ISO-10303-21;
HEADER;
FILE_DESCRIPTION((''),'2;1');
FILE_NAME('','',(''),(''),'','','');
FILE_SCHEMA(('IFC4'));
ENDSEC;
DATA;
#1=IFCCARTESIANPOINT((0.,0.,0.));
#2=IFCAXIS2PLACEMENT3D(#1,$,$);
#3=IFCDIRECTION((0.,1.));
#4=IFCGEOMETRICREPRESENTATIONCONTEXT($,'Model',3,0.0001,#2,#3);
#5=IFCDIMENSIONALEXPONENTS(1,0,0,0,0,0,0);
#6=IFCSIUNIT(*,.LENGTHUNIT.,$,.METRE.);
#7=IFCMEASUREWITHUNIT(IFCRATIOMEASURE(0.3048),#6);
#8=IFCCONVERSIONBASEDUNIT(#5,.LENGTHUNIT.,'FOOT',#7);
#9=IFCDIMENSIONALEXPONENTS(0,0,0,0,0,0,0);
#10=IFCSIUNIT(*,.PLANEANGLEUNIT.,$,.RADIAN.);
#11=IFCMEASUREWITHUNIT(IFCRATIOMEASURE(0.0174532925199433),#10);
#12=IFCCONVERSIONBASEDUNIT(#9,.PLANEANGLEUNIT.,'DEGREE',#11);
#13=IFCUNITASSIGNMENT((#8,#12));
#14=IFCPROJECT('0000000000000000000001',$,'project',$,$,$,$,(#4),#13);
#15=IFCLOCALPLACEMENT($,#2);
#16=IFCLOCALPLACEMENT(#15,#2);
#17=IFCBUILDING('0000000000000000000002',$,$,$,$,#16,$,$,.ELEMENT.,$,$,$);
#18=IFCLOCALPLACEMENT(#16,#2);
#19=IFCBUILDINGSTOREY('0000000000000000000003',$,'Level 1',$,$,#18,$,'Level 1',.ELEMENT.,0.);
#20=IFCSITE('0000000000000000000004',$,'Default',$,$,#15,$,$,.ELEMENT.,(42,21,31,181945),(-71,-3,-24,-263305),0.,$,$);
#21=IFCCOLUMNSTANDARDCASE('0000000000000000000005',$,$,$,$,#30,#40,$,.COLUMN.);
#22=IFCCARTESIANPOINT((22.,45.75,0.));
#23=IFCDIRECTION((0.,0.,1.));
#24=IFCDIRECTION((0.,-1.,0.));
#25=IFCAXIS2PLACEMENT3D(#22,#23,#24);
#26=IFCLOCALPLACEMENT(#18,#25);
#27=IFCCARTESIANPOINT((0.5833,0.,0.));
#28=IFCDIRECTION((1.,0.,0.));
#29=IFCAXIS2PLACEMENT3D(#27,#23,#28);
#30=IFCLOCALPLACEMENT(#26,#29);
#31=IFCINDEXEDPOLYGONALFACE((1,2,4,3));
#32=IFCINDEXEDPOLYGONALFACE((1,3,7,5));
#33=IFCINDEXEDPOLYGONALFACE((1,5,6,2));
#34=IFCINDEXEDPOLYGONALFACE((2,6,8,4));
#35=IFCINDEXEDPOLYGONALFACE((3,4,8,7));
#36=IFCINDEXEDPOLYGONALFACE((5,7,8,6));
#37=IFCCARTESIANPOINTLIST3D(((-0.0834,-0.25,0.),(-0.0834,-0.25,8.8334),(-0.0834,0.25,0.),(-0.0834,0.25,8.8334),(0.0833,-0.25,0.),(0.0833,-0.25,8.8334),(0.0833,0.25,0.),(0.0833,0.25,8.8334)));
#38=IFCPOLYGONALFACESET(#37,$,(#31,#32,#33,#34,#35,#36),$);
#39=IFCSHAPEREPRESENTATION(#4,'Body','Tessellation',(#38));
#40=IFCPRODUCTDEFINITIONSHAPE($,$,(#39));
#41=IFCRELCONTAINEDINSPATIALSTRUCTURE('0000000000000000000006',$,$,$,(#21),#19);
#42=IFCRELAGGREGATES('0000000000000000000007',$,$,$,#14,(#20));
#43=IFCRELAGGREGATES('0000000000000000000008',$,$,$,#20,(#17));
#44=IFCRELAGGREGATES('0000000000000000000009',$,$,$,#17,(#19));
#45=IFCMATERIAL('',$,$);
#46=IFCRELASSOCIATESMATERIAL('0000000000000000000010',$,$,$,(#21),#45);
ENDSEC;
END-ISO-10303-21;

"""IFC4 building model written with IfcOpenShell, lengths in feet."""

from ifc_helpers import new_model, entity, si_unit, converted_unit, direction, frame, origin, place, context, project, spatial, rectangle, extrude, material, element, save


model = new_model("IFC4")

# Units and contexts
model_context = context("Model", 3, precision=0.0001, world=origin(), true_north=direction((0.0, 1.0)))
ifc_project = project(units=[converted_unit("LENGTHUNIT", "FOOT", entity("IfcRatioMeasure", 0.3048), si_unit("LENGTHUNIT", "METRE"), dimensions=[1, 0, 0, 0, 0, 0, 0]), converted_unit("PLANEANGLEUNIT", "DEGREE", entity("IfcRatioMeasure", 0.0174532925199433), si_unit("PLANEANGLEUNIT", "RADIAN"), dimensions=[0, 0, 0, 0, 0, 0, 0])], contexts=[model_context])

# Site, building, storey
site_placement = place(None, origin())
site = spatial("IfcSite", under=ifc_project, at=site_placement, Name="Default", CompositionType="ELEMENT", RefLatitude=(42, 21, 31, 181945), RefLongitude=(-71, -3, -24, -263305), RefElevation=0.0)
building_placement = place(site_placement, origin())
building = spatial("IfcBuilding", under=site, at=building_placement, CompositionType="ELEMENT")
storey_placement = place(building_placement, origin())
storey = spatial("IfcBuildingStorey", under=building, at=storey_placement, Name="Level 1", LongName="Level 1", CompositionType="ELEMENT", Elevation=0.0)

# Column
ifc_material_1 = material(Name="")
placement_1 = place(storey_placement, frame((22.0, 45.75, 0.0), z_axis=(0.0, 0.0, 1.0), x_axis=(0.0, -1.0, 0.0)))
for number, where, z_axis, x_axis in (
    (1, (0.5833, 0.0, 0.0), (0.0, 0.0, 1.0), (1.0, 0.0, 0.0)),
):
    element("IfcColumnStandardCase", number, at=place(placement_1, frame(where, z_axis=z_axis, x_axis=x_axis)), inside=storey, material=ifc_material_1, PredefinedType="COLUMN", context=model_context, shape_type="SweptSolid", body=[
        extrude(rectangle(XDim=0.1667, YDim=0.5), origin(), (0.0, 0.0, 1.0), 8.8334),
    ])

save(model, "model.ifc")
